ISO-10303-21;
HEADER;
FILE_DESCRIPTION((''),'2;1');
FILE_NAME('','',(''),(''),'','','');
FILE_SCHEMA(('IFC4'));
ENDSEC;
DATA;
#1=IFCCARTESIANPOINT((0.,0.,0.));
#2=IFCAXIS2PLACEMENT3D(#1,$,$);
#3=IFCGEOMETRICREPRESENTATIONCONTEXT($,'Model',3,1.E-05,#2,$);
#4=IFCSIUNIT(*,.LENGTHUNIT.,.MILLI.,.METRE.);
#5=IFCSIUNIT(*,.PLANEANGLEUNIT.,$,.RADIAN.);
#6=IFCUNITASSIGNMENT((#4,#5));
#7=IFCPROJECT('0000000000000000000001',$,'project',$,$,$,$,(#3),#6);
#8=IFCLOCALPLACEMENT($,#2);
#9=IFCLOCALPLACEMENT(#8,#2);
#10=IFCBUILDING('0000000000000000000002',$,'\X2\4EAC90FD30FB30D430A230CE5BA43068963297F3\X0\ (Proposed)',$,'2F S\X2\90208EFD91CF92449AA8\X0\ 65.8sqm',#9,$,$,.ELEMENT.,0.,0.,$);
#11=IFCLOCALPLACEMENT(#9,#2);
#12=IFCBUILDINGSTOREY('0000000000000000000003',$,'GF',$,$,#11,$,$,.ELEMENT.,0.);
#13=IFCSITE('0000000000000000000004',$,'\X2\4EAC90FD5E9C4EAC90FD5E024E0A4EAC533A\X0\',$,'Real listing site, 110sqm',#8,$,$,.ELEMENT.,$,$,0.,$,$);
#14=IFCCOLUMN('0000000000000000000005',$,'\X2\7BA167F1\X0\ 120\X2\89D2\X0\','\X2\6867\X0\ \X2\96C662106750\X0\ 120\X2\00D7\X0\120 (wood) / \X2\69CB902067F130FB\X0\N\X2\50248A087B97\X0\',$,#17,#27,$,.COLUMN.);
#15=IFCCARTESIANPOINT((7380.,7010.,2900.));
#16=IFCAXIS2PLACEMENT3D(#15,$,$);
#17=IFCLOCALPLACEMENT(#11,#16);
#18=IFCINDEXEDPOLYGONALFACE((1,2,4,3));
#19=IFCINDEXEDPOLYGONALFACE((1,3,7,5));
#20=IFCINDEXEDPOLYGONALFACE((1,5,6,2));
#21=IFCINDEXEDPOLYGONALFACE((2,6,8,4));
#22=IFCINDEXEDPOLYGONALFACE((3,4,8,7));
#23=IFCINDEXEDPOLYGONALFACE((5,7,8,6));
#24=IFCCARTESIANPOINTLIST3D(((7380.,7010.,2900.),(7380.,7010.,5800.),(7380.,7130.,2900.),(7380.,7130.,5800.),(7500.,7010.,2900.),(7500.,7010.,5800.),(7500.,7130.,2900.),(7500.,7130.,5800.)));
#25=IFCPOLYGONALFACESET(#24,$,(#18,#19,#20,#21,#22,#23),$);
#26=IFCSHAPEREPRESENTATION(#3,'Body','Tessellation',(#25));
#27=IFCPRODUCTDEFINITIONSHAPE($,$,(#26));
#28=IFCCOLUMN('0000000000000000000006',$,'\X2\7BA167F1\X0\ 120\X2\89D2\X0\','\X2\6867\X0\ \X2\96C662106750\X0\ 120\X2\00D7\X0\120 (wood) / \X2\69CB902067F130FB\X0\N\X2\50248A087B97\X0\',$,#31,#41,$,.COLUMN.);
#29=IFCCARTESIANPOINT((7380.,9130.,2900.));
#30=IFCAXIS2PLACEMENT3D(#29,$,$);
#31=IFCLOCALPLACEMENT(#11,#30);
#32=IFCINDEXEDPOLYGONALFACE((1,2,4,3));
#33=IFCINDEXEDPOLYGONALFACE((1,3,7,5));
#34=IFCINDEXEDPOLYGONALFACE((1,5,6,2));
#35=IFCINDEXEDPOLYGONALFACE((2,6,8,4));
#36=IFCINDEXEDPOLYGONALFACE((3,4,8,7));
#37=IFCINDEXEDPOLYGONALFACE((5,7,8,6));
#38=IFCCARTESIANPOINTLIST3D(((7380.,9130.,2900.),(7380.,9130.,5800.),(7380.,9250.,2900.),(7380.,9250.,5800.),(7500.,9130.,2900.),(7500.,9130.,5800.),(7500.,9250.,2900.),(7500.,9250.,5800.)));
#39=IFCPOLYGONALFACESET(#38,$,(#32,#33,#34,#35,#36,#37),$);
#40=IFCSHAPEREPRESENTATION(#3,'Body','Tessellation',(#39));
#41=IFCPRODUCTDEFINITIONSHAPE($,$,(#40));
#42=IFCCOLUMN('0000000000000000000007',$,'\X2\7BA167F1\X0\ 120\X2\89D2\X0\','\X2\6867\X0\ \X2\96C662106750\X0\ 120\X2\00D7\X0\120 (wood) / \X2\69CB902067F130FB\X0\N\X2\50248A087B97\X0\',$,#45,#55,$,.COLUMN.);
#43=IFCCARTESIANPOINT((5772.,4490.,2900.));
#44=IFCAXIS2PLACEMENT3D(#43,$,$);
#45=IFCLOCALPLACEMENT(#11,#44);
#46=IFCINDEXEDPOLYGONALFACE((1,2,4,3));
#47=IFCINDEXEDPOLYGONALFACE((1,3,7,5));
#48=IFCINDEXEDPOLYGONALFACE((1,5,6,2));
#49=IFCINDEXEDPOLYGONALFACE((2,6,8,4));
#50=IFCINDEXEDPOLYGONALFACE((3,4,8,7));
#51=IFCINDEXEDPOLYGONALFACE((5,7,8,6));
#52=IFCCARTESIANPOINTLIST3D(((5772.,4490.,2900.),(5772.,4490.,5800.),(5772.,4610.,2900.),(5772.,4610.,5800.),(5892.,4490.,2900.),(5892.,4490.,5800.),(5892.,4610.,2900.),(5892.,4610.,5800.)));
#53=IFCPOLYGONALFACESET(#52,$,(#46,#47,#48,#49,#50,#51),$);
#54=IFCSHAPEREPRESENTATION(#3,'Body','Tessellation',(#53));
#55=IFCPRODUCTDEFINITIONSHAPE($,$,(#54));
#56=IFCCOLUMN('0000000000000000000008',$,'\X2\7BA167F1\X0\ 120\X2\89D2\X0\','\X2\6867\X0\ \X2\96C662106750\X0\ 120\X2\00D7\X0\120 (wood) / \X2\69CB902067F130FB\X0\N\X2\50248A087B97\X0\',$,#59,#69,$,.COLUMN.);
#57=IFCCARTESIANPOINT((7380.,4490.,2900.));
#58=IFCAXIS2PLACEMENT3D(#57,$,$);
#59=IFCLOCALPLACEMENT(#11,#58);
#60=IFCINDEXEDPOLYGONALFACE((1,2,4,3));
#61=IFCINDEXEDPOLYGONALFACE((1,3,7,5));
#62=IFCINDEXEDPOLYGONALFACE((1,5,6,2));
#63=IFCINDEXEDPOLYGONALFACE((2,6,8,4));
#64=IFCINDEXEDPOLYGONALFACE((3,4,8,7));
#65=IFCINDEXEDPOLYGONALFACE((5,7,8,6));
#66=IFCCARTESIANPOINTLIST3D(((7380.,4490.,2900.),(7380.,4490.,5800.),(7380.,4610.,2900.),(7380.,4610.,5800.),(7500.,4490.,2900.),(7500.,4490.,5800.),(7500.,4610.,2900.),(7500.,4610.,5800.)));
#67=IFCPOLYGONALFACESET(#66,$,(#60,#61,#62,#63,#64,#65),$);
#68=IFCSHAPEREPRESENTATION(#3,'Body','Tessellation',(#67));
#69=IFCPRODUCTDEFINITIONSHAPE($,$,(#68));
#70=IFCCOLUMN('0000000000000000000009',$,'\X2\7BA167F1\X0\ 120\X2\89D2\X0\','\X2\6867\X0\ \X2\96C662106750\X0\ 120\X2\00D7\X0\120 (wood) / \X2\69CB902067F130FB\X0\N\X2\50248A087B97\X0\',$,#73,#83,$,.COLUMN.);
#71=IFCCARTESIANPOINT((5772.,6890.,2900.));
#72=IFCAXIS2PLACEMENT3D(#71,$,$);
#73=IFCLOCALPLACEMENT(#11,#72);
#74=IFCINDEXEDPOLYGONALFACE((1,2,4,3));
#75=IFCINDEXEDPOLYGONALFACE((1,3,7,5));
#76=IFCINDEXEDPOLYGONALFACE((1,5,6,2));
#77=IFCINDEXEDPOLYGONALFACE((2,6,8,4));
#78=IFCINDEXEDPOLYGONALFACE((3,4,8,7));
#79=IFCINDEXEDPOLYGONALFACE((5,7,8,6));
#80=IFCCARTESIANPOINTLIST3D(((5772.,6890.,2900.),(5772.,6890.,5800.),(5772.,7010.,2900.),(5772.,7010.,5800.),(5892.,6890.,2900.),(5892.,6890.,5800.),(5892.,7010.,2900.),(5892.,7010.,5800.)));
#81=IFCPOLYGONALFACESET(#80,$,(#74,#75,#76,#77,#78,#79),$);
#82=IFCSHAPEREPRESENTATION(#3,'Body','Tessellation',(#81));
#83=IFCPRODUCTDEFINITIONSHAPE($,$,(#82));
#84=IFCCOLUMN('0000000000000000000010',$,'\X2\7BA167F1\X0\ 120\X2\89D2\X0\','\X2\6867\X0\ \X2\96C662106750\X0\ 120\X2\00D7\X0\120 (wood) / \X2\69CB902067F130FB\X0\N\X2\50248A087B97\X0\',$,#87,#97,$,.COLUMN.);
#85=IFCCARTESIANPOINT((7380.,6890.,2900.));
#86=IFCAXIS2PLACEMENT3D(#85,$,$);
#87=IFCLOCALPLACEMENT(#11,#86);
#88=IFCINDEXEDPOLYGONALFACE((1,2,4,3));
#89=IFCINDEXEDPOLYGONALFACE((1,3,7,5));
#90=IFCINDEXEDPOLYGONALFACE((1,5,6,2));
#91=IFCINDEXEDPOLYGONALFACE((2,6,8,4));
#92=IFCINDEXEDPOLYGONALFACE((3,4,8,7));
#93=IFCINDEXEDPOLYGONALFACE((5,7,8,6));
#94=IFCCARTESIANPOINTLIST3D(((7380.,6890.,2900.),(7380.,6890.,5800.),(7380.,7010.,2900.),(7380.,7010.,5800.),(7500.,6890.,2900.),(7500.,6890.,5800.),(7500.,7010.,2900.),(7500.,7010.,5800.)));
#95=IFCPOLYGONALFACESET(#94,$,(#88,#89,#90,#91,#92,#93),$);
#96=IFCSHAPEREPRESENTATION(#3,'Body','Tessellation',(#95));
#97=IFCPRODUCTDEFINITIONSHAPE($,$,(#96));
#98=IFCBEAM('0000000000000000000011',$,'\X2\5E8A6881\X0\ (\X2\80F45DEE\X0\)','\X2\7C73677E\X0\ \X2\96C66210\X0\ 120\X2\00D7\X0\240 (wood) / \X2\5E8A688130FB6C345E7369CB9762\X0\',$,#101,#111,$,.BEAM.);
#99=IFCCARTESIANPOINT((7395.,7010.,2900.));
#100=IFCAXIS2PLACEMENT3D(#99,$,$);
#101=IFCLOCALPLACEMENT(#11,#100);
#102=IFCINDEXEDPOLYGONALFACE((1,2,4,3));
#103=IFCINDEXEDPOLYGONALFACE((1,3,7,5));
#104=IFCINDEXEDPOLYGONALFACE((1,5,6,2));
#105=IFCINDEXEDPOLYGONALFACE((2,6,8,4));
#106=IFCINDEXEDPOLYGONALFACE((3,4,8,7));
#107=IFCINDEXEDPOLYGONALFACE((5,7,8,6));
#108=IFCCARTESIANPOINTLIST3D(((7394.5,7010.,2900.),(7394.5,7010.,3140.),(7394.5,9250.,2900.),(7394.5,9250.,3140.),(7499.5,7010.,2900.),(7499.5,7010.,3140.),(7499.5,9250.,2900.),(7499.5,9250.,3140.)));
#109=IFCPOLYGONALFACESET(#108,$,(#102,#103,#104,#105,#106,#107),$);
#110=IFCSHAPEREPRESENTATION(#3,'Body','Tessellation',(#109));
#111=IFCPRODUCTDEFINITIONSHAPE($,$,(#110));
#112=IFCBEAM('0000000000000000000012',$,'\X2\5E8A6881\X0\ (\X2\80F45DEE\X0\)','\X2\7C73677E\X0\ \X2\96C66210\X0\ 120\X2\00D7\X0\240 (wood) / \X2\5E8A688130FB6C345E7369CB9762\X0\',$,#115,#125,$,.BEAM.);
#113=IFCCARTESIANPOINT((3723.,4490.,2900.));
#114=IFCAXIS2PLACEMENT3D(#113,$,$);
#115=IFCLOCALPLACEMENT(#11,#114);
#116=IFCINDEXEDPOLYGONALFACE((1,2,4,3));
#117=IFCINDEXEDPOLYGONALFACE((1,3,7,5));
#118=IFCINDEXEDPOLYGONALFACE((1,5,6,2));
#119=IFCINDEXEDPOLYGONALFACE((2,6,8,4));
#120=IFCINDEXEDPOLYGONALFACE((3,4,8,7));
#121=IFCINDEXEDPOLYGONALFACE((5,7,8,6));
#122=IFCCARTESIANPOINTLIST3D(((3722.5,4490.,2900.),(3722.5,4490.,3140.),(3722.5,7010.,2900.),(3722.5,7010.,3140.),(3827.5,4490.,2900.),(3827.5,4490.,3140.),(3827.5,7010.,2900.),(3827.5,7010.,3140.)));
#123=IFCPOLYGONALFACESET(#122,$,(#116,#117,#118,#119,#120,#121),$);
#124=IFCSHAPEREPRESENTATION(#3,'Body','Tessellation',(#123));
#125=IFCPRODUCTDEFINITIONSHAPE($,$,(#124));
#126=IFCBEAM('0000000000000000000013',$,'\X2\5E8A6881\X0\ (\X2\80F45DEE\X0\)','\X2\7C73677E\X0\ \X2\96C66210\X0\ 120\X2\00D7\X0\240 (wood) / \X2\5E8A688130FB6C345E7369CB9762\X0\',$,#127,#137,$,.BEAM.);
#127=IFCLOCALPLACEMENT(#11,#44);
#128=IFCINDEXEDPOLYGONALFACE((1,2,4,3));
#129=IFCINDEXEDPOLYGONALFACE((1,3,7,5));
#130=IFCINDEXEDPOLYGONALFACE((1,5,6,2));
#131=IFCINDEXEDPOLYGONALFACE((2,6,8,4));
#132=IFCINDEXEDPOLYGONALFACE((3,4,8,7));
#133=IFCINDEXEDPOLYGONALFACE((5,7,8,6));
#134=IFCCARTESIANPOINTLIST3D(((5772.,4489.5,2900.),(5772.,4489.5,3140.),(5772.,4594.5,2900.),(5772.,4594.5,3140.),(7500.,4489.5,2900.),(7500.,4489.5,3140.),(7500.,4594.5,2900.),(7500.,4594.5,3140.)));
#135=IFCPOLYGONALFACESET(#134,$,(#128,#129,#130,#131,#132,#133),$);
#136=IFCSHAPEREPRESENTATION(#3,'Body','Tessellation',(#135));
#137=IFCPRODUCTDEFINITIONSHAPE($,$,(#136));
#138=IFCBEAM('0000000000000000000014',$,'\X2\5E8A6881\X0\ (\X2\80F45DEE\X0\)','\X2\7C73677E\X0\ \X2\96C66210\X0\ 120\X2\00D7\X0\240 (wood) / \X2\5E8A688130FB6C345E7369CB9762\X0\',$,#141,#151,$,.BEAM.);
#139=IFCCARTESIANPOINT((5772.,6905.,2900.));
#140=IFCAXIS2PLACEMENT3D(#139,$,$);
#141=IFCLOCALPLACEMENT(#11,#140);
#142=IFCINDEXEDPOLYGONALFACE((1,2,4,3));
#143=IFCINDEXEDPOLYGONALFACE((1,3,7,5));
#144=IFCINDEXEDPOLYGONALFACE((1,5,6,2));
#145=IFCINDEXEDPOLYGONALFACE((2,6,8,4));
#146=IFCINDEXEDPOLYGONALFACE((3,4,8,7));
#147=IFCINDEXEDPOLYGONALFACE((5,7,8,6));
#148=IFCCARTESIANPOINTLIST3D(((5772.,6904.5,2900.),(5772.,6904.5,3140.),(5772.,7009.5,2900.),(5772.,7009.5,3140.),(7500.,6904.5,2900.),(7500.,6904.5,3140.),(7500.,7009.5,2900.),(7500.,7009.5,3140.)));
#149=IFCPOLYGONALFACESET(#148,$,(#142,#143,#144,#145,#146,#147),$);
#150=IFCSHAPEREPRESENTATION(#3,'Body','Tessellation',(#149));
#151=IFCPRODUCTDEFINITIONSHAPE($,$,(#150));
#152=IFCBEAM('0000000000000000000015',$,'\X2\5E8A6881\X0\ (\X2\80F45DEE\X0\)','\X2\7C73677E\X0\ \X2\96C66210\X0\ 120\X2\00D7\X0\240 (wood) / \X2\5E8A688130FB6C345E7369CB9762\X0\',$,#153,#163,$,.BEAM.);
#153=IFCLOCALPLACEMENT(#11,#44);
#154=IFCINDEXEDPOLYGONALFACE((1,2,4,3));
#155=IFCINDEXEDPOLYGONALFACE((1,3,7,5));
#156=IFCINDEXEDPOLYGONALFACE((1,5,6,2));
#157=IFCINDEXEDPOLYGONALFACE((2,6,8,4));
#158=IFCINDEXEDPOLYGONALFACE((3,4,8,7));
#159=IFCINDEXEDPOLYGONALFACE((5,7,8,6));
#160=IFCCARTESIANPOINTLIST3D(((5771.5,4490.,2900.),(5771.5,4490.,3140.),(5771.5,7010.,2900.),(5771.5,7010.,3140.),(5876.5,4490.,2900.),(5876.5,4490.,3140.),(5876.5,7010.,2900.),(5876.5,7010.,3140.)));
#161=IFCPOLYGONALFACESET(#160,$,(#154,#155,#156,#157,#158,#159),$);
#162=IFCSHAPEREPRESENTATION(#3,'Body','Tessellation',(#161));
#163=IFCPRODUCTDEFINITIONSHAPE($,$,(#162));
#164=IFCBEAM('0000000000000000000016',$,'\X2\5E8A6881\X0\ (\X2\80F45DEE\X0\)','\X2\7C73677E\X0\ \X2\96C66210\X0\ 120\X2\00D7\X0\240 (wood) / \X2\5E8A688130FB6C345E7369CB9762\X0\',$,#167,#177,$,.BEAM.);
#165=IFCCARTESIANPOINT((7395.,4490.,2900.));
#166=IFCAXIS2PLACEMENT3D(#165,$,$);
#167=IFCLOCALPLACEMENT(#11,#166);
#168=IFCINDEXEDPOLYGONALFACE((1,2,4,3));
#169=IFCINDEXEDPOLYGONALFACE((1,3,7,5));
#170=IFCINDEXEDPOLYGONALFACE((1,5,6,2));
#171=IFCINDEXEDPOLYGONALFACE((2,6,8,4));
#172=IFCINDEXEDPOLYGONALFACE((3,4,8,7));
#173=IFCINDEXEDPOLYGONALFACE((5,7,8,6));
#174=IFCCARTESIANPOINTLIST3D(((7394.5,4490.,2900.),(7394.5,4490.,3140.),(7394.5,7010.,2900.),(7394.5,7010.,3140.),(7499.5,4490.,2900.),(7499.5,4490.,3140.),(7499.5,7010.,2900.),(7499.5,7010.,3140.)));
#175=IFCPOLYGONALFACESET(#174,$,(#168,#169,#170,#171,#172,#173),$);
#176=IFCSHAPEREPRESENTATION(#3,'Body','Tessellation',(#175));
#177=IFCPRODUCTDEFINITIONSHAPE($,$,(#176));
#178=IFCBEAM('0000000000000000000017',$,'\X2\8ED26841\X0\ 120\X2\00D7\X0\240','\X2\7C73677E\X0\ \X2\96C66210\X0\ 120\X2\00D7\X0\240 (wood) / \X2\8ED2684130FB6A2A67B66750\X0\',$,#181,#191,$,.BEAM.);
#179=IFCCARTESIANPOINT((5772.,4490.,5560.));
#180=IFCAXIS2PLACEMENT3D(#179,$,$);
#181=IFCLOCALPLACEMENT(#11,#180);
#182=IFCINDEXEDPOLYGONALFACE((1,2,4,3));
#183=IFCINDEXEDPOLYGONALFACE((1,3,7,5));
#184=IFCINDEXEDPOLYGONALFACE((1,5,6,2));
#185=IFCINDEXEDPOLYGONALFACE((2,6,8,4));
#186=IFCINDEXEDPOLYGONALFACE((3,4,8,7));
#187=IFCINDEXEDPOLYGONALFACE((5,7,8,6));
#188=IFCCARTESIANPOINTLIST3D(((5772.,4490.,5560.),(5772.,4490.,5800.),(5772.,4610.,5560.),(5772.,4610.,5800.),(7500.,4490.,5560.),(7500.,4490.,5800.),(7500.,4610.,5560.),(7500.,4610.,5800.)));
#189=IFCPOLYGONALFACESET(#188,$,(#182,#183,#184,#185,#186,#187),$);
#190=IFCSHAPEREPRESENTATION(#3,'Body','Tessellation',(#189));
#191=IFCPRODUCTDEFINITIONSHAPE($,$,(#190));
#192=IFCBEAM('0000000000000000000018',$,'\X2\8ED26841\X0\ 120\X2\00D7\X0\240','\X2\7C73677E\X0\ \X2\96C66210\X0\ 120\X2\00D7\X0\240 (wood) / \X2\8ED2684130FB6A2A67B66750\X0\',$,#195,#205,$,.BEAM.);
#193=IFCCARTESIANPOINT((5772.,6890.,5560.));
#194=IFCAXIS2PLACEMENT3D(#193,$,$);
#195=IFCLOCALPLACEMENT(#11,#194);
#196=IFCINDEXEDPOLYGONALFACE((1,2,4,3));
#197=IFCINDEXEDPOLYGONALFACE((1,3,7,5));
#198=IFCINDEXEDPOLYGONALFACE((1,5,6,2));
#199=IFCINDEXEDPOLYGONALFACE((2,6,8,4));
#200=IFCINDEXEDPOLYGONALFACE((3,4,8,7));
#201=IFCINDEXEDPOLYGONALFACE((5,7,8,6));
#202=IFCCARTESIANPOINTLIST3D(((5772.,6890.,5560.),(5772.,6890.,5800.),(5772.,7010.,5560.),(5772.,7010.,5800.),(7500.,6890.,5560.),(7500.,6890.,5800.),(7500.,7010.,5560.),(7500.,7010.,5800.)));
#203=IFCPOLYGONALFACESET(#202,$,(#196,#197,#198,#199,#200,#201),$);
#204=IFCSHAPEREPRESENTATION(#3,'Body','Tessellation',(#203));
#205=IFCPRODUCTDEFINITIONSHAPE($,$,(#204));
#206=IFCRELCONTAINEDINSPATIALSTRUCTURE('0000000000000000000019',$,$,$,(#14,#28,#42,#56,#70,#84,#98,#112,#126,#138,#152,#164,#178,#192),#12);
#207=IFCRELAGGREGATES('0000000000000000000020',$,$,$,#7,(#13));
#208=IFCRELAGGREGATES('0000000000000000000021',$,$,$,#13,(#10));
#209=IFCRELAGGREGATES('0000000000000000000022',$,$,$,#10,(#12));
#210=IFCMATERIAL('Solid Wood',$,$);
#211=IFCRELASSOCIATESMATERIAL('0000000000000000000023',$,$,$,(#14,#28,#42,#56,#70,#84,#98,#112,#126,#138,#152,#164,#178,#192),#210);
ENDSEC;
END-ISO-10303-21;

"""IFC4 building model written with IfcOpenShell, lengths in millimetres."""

from ifc_helpers import new_model, si_unit, frame, frame_2d, origin, place, context, project, spatial, rectangle, extrude, material, element, save


model = new_model("IFC4")

# Units and contexts
model_context = context("Model", 3, precision=1e-05, world=origin())
ifc_project = project(units=[si_unit("LENGTHUNIT", "METRE", prefix="MILLI"), si_unit("PLANEANGLEUNIT", "RADIAN")], contexts=[model_context])

# Site, building, storey
site_placement = place(None, origin())
site = spatial("IfcSite", under=ifc_project, at=site_placement, Name="京都府京都市上京区", ObjectType="Real listing site, 110sqm", CompositionType="ELEMENT", RefElevation=0.0)
building_placement = place(site_placement, origin())
building = spatial("IfcBuilding", under=site, at=building_placement, Name="京都・ピアノ室と防音 (Proposed)", ObjectType="2F S造軽量鉄骨 65.8sqm", CompositionType="ELEMENT", ElevationOfRefHeight=0.0, ElevationOfTerrain=0.0)
storey_placement = place(building_placement, origin())
storey = spatial("IfcBuildingStorey", under=building, at=storey_placement, Name="GF", CompositionType="ELEMENT", Elevation=0.0)

# Columns
ifc_material_1 = material(Name="Solid Wood")
column_1_placement = place(storey_placement, frame((7380.0, 7010.0, 2900.0)))
element("IfcColumn", 1, at=column_1_placement, inside=storey, material=ifc_material_1, Name="管柱 120角", Description="桧 集成材 120×120 (wood) / 構造柱・N値計算", PredefinedType="COLUMN", context=model_context, shape_type="SweptSolid", body=[
    extrude(rectangle(XDim=120.0, YDim=120.0, at=frame_2d((60.0, 60.0))), frame((7380.0, 7010.0, 2900.0)), (0.0, 0.0, 1.0), 2900.0),
])
column_2_placement = place(storey_placement, frame((7380.0, 9130.0, 2900.0)))
element("IfcColumn", 2, at=column_2_placement, inside=storey, material=ifc_material_1, Name="管柱 120角", Description="桧 集成材 120×120 (wood) / 構造柱・N値計算", PredefinedType="COLUMN", context=model_context, shape_type="SweptSolid", body=[
    extrude(rectangle(XDim=120.0, YDim=120.0, at=frame_2d((60.0, 60.0))), frame((7380.0, 9130.0, 2900.0)), (0.0, 0.0, 1.0), 2900.0),
])
column_3_placement = place(storey_placement, frame((5772.0, 4490.0, 2900.0)))
element("IfcColumn", 3, at=column_3_placement, inside=storey, material=ifc_material_1, Name="管柱 120角", Description="桧 集成材 120×120 (wood) / 構造柱・N値計算", PredefinedType="COLUMN", context=model_context, shape_type="SweptSolid", body=[
    extrude(rectangle(XDim=120.0, YDim=120.0, at=frame_2d((60.0, 60.0))), frame((5772.0, 4490.0, 2900.0)), (0.0, 0.0, 1.0), 2900.0),
])
column_4_placement = place(storey_placement, frame((7380.0, 4490.0, 2900.0)))
element("IfcColumn", 4, at=column_4_placement, inside=storey, material=ifc_material_1, Name="管柱 120角", Description="桧 集成材 120×120 (wood) / 構造柱・N値計算", PredefinedType="COLUMN", context=model_context, shape_type="SweptSolid", body=[
    extrude(rectangle(XDim=120.0, YDim=120.0, at=frame_2d((60.0, 60.0))), frame((7380.0, 4490.0, 2900.0)), (0.0, 0.0, 1.0), 2900.0),
])
column_5_placement = place(storey_placement, frame((5772.0, 6890.0, 2900.0)))
element("IfcColumn", 5, at=column_5_placement, inside=storey, material=ifc_material_1, Name="管柱 120角", Description="桧 集成材 120×120 (wood) / 構造柱・N値計算", PredefinedType="COLUMN", context=model_context, shape_type="SweptSolid", body=[
    extrude(rectangle(XDim=120.0, YDim=120.0, at=frame_2d((60.0, 60.0))), frame((5772.0, 6890.0, 2900.0)), (0.0, 0.0, 1.0), 2900.0),
])
column_6_placement = place(storey_placement, frame((7380.0, 6890.0, 2900.0)))
element("IfcColumn", 6, at=column_6_placement, inside=storey, material=ifc_material_1, Name="管柱 120角", Description="桧 集成材 120×120 (wood) / 構造柱・N値計算", PredefinedType="COLUMN", context=model_context, shape_type="SweptSolid", body=[
    extrude(rectangle(XDim=120.0, YDim=120.0, at=frame_2d((60.0, 60.0))), frame((7380.0, 6890.0, 2900.0)), (0.0, 0.0, 1.0), 2900.0),
])

# Beams
beam_1_placement = place(storey_placement, frame((7395.0, 7010.0, 2900.0)))
element("IfcBeam", 7, at=beam_1_placement, inside=storey, material=ifc_material_1, Name="床梁 (胴差)", Description="米松 集成 120×240 (wood) / 床梁・水平構面", PredefinedType="BEAM", context=model_context, shape_type="SweptSolid", body=[
    extrude(rectangle(XDim=105.0, YDim=2240.0, at=frame_2d((52.0, 1120.0))), frame((7395.0, 7010.0, 2900.0)), (0.0, 0.0, 1.0), 240.0),
])
beam_2_placement = place(storey_placement, frame((3723.0, 4490.0, 2900.0)))
element("IfcBeam", 8, at=beam_2_placement, inside=storey, material=ifc_material_1, Name="床梁 (胴差)", Description="米松 集成 120×240 (wood) / 床梁・水平構面", PredefinedType="BEAM", context=model_context, shape_type="SweptSolid", body=[
    extrude(rectangle(XDim=105.0, YDim=2520.0, at=frame_2d((52.0, 1260.0))), frame((3723.0, 4490.0, 2900.0)), (0.0, 0.0, 1.0), 240.0),
])
beam_3_placement = place(storey_placement, frame((5772.0, 4490.0, 2900.0)))
element("IfcBeam", 9, at=beam_3_placement, inside=storey, material=ifc_material_1, Name="床梁 (胴差)", Description="米松 集成 120×240 (wood) / 床梁・水平構面", PredefinedType="BEAM", context=model_context, shape_type="SweptSolid", body=[
    extrude(rectangle(XDim=1728.0, YDim=105.0, at=frame_2d((864.0, 52.0))), frame((5772.0, 4490.0, 2900.0)), (0.0, 0.0, 1.0), 240.0),
])
beam_4_placement = place(storey_placement, frame((5772.0, 6905.0, 2900.0)))
element("IfcBeam", 10, at=beam_4_placement, inside=storey, material=ifc_material_1, Name="床梁 (胴差)", Description="米松 集成 120×240 (wood) / 床梁・水平構面", PredefinedType="BEAM", context=model_context, shape_type="SweptSolid", body=[
    extrude(rectangle(XDim=1728.0, YDim=105.0, at=frame_2d((864.0, 52.0))), frame((5772.0, 6905.0, 2900.0)), (0.0, 0.0, 1.0), 240.0),
])
beam_5_placement = place(storey_placement, frame((5772.0, 4490.0, 2900.0)))
element("IfcBeam", 11, at=beam_5_placement, inside=storey, material=ifc_material_1, Name="床梁 (胴差)", Description="米松 集成 120×240 (wood) / 床梁・水平構面", PredefinedType="BEAM", context=model_context, shape_type="SweptSolid", body=[
    extrude(rectangle(XDim=105.0, YDim=2520.0, at=frame_2d((52.0, 1260.0))), frame((5772.0, 4490.0, 2900.0)), (0.0, 0.0, 1.0), 240.0),
])
beam_6_placement = place(storey_placement, frame((7395.0, 4490.0, 2900.0)))
element("IfcBeam", 12, at=beam_6_placement, inside=storey, material=ifc_material_1, Name="床梁 (胴差)", Description="米松 集成 120×240 (wood) / 床梁・水平構面", PredefinedType="BEAM", context=model_context, shape_type="SweptSolid", body=[
    extrude(rectangle(XDim=105.0, YDim=2520.0, at=frame_2d((52.0, 1260.0))), frame((7395.0, 4490.0, 2900.0)), (0.0, 0.0, 1.0), 240.0),
])
beam_7_placement = place(storey_placement, frame((5772.0, 4490.0, 5560.0)))
element("IfcBeam", 13, at=beam_7_placement, inside=storey, material=ifc_material_1, Name="軒桁 120×240", Description="米松 集成 120×240 (wood) / 軒桁・横架材", PredefinedType="BEAM", context=model_context, shape_type="SweptSolid", body=[
    extrude(rectangle(XDim=1728.0, YDim=120.0, at=frame_2d((864.0, 60.0))), frame((5772.0, 4490.0, 5560.0)), (0.0, 0.0, 1.0), 240.0),
])
beam_8_placement = place(storey_placement, frame((5772.0, 6890.0, 5560.0)))
element("IfcBeam", 14, at=beam_8_placement, inside=storey, material=ifc_material_1, Name="軒桁 120×240", Description="米松 集成 120×240 (wood) / 軒桁・横架材", PredefinedType="BEAM", context=model_context, shape_type="SweptSolid", body=[
    extrude(rectangle(XDim=1728.0, YDim=120.0, at=frame_2d((864.0, 60.0))), frame((5772.0, 6890.0, 5560.0)), (0.0, 0.0, 1.0), 240.0),
])

save(model, "model.ifc")
